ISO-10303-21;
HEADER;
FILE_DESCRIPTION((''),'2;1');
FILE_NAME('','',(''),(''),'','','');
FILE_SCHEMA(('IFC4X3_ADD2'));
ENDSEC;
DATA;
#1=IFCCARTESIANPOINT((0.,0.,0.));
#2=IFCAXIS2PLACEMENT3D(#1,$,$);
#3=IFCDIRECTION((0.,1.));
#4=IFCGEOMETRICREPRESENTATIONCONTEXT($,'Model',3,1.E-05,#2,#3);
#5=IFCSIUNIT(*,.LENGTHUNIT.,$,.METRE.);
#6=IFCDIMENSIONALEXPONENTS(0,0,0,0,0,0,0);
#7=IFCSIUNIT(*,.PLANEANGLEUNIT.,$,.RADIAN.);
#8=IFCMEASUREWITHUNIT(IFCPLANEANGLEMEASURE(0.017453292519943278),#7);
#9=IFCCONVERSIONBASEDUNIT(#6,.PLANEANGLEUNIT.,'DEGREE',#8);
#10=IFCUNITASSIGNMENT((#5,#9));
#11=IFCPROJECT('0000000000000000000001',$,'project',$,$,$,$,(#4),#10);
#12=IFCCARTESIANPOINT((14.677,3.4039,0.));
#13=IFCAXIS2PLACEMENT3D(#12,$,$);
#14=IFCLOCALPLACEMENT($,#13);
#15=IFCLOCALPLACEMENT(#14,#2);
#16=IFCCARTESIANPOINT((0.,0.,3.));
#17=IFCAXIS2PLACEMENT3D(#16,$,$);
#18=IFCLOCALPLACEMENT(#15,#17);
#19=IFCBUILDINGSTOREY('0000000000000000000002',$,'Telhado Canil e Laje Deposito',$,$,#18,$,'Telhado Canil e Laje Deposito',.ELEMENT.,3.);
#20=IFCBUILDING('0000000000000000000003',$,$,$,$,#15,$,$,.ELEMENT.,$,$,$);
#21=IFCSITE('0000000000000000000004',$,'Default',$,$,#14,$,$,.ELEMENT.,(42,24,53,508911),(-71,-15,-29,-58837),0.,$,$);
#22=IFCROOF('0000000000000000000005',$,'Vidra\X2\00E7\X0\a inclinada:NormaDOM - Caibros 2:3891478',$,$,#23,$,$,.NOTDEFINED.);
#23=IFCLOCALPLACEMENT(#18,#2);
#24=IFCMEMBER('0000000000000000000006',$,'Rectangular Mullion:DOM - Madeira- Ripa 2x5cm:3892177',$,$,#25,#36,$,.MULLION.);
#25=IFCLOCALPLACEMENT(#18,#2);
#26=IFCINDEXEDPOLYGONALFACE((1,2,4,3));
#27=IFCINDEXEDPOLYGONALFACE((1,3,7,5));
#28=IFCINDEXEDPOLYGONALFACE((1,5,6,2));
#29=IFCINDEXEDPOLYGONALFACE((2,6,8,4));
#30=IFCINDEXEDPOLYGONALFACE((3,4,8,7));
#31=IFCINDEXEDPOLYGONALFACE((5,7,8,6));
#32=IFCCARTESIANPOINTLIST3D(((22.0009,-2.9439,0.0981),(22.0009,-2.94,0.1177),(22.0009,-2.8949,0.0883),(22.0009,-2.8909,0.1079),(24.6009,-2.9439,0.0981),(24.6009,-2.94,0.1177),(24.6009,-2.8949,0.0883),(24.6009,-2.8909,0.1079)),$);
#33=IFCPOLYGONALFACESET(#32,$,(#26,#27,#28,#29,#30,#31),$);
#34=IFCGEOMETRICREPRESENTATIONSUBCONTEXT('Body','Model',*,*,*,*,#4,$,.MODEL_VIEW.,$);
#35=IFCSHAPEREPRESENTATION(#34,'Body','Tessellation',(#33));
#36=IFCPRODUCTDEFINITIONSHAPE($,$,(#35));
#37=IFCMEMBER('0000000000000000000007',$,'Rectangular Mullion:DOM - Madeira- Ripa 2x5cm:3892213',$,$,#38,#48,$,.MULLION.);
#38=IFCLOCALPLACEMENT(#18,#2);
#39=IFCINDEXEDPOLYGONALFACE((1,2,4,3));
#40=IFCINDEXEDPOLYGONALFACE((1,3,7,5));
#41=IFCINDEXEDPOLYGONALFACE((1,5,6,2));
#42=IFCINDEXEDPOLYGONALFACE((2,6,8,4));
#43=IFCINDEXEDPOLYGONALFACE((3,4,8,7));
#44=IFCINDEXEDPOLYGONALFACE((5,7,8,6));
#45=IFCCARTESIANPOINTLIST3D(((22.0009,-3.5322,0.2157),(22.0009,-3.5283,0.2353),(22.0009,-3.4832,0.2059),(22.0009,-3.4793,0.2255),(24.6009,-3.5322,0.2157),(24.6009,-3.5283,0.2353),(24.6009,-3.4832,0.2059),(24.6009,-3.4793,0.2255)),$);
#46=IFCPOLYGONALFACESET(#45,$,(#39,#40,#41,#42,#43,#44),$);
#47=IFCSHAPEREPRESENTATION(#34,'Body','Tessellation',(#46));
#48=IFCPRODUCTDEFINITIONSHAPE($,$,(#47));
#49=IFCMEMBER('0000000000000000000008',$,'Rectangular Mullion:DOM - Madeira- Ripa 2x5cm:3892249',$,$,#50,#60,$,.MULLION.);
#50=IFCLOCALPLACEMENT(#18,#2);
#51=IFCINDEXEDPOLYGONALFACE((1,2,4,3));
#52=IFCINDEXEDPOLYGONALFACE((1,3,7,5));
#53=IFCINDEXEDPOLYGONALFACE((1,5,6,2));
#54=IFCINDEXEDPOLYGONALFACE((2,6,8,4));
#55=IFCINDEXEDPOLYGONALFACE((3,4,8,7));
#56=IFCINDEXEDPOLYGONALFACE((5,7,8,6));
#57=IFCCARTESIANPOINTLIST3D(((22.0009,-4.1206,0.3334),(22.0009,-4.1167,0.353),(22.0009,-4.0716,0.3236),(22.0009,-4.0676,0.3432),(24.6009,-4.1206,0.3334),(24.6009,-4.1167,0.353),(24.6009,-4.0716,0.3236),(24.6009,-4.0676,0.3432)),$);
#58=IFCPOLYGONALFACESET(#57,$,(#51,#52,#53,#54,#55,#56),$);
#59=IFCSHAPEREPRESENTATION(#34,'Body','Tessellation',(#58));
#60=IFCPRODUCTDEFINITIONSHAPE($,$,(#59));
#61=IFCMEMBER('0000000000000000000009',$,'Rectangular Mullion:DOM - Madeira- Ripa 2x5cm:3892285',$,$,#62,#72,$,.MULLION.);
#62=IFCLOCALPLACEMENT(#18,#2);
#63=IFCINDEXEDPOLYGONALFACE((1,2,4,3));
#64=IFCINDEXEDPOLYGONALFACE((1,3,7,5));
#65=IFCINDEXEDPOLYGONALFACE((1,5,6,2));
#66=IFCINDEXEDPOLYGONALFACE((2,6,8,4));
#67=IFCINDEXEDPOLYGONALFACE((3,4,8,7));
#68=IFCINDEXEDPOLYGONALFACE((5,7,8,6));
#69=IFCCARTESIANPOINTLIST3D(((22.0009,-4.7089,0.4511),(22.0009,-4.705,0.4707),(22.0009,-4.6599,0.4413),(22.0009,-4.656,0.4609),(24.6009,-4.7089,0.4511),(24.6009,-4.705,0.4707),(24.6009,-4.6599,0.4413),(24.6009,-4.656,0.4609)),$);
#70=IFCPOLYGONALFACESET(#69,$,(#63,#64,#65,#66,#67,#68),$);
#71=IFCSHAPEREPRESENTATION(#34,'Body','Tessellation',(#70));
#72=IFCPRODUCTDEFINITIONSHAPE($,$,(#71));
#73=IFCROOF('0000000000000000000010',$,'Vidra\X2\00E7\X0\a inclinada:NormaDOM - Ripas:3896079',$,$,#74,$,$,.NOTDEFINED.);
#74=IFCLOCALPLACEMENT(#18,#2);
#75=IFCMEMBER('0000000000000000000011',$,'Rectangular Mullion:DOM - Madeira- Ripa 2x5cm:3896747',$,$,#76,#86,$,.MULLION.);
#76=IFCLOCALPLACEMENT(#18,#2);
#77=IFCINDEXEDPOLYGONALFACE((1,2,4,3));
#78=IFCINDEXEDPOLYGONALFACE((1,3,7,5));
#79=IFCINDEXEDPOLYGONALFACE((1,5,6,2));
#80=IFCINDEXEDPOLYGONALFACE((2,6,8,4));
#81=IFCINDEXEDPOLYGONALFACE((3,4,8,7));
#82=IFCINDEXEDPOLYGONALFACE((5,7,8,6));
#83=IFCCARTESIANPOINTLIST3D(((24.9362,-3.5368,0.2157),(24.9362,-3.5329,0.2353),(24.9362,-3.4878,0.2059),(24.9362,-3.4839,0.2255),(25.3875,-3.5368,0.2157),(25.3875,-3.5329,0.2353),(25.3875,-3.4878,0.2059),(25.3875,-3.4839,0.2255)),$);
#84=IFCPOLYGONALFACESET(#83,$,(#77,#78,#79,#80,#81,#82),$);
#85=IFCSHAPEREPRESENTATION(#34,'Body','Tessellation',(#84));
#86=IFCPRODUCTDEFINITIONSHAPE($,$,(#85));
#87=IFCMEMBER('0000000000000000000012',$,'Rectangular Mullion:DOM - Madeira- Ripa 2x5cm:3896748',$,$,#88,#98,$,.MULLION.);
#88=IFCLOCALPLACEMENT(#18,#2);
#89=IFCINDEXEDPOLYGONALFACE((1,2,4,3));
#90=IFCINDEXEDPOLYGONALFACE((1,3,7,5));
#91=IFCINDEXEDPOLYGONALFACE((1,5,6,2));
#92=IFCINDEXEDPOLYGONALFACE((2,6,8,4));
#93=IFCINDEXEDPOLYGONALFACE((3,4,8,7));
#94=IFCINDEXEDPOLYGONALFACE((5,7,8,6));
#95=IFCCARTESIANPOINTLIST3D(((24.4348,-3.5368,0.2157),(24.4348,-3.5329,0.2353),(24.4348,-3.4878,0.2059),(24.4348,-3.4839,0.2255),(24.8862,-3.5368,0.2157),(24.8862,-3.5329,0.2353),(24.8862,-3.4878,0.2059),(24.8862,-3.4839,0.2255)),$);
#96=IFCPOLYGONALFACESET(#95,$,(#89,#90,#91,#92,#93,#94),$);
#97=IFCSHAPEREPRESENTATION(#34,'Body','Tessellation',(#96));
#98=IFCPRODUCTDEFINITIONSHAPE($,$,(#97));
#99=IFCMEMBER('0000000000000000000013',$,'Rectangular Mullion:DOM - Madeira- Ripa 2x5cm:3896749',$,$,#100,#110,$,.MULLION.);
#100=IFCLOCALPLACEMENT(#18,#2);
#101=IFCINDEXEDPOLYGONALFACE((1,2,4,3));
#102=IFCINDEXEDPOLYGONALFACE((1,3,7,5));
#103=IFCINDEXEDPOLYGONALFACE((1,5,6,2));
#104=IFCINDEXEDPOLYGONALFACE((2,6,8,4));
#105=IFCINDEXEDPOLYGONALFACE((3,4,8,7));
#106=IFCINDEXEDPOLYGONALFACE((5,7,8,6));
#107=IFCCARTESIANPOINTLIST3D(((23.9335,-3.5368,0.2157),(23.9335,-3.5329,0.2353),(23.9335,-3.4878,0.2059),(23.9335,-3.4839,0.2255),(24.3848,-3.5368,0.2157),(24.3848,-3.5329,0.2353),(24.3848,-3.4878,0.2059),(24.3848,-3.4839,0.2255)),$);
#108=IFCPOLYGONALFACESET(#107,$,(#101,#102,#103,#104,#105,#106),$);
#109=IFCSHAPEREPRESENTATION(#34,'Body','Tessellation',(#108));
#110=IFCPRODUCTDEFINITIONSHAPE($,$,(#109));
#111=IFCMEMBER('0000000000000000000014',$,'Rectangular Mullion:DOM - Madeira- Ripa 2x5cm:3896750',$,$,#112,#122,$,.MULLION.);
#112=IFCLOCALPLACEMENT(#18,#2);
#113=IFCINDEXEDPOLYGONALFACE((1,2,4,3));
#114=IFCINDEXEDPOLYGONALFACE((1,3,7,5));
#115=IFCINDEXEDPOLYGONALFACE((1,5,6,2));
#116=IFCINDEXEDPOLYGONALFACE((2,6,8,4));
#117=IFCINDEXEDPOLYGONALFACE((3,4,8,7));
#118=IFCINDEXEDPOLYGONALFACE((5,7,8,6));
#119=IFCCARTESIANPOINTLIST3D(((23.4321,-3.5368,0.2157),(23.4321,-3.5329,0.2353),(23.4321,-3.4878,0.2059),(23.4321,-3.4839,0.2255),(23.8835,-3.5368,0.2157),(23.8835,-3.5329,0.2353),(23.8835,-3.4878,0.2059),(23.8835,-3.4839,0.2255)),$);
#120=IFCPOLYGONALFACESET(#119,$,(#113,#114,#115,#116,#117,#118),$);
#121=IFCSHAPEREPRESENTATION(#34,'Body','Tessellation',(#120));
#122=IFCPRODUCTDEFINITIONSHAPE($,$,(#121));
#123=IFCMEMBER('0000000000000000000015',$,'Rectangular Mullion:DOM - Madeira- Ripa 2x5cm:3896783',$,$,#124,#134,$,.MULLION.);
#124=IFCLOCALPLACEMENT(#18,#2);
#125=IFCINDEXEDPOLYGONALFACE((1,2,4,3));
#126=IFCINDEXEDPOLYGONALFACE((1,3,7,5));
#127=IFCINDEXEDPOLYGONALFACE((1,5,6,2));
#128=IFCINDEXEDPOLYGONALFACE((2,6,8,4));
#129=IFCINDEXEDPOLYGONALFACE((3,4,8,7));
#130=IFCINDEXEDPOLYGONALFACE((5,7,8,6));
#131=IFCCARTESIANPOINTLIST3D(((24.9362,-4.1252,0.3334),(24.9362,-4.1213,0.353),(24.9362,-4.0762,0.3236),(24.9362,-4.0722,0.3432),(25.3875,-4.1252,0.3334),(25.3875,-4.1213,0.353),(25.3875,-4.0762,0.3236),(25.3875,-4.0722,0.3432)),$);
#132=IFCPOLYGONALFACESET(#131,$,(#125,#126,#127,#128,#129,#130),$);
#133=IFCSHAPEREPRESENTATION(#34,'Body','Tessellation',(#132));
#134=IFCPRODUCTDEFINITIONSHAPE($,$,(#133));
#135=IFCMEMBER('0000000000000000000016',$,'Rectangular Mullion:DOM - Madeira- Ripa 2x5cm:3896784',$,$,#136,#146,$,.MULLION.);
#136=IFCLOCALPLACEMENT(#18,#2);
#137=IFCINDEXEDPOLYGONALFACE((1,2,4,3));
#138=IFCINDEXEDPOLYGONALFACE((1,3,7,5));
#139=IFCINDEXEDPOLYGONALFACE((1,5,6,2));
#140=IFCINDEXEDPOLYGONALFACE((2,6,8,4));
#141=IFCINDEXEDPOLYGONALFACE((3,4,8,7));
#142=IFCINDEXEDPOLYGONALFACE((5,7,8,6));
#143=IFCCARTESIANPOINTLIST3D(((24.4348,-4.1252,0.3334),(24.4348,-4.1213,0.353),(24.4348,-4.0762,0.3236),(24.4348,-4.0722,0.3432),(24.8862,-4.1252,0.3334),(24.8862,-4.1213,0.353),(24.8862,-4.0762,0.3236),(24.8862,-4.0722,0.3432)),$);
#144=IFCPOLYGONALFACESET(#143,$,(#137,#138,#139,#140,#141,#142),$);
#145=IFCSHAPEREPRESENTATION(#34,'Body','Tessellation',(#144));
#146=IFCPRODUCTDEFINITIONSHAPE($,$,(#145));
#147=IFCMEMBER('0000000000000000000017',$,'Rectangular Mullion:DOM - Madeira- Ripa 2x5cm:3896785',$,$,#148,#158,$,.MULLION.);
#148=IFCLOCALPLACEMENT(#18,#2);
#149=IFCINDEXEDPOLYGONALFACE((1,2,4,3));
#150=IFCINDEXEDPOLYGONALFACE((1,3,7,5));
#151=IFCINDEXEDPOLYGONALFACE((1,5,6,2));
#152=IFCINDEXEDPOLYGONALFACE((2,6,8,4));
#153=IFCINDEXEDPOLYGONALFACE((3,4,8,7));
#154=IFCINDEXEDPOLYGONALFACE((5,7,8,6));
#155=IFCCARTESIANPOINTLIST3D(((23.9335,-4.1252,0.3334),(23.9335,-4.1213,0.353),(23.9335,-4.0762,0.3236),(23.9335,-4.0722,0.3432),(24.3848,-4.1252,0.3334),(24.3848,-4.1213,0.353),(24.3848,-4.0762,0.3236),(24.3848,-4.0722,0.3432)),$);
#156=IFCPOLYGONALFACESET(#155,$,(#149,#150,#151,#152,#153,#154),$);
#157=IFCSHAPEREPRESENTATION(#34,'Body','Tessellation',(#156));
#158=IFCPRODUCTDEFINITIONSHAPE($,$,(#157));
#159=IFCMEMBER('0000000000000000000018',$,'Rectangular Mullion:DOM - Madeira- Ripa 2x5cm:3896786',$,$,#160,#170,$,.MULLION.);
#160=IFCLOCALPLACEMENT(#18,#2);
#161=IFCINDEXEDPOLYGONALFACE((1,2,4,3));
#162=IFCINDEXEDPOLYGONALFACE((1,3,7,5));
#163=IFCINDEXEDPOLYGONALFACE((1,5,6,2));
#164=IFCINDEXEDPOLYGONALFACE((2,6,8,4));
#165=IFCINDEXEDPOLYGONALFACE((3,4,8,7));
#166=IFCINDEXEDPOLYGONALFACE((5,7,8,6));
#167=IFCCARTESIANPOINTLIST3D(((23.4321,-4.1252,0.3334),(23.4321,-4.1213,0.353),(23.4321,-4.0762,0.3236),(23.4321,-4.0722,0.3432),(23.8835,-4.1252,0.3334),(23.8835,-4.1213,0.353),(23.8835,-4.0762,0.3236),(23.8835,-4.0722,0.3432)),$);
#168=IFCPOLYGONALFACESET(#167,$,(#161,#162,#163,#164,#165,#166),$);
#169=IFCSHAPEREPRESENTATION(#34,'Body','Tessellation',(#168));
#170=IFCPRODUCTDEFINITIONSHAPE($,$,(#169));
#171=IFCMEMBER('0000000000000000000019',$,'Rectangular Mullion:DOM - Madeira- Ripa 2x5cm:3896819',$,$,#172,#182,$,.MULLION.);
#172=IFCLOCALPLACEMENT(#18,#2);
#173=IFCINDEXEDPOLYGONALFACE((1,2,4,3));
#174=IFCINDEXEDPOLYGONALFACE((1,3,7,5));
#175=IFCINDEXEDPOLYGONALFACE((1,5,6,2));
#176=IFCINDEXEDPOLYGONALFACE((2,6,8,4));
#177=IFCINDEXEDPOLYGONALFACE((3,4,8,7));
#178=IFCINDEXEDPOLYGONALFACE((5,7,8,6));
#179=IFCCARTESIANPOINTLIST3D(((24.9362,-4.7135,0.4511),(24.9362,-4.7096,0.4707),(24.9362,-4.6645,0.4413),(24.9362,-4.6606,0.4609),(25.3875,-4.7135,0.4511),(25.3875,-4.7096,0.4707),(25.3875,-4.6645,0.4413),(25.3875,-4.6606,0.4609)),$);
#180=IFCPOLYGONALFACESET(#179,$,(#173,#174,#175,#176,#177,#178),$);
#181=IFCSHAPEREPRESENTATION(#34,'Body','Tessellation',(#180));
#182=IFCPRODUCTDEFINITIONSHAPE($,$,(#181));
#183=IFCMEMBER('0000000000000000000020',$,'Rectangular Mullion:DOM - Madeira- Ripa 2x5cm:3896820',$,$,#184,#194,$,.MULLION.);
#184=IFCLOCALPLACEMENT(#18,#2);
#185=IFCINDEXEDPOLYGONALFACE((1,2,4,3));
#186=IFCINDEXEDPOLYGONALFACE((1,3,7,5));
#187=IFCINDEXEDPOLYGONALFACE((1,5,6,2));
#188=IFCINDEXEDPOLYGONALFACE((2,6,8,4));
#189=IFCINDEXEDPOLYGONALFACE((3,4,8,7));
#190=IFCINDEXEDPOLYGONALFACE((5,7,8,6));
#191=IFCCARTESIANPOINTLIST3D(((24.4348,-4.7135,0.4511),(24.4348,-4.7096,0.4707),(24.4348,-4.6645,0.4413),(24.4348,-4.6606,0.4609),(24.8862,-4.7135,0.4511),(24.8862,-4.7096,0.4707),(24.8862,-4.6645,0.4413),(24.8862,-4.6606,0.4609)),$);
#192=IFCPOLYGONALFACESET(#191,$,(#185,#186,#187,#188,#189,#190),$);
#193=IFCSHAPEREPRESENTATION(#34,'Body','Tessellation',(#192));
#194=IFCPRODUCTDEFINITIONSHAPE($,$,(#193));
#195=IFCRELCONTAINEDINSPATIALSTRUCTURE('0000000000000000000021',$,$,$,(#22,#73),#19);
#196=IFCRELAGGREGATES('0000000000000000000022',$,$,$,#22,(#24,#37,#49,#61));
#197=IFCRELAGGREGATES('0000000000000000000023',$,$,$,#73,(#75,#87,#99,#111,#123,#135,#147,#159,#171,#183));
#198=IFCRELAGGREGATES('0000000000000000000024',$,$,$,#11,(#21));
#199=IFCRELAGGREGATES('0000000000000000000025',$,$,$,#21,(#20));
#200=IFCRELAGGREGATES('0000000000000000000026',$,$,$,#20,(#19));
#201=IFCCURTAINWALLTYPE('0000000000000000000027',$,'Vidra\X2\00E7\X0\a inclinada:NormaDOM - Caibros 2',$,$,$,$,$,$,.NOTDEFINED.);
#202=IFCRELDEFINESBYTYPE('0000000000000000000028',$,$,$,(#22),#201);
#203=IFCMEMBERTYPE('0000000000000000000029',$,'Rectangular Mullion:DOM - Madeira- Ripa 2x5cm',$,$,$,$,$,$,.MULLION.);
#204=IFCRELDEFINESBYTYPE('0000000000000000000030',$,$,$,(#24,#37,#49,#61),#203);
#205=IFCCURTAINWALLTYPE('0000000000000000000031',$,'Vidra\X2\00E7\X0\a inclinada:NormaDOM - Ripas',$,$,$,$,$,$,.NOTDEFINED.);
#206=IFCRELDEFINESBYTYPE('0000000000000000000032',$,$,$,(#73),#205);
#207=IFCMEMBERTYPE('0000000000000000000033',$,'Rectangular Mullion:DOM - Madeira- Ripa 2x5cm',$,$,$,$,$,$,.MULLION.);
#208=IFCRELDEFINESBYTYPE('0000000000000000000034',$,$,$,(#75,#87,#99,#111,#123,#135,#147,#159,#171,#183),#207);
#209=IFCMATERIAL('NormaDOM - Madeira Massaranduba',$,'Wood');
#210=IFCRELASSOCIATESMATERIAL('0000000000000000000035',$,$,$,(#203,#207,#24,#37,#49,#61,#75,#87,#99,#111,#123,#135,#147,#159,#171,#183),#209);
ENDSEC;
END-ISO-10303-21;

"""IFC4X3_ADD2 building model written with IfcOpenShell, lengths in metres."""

from ifc_helpers import new_model, entity, si_unit, converted_unit, direction, frame, origin, origin_2d_with_axis, place, context, subcontext, project, spatial, rectangle, extrude, source, transform, mapped, material, material_profile, profile_set, profile_usage, type_object, type_shapes, element, aggregate, save


model = new_model("IFC4X3_ADD2")

# Units and contexts
model_context = context("Model", 3, precision=1e-05, world=origin(), true_north=direction((0.0, 1.0)))
body_context = subcontext(model_context, "Body", "Model", "MODEL_VIEW")
ifc_project = project(units=[si_unit("LENGTHUNIT", "METRE"), converted_unit("PLANEANGLEUNIT", "DEGREE", entity("IfcPlaneAngleMeasure", 0.017453292519943278), si_unit("PLANEANGLEUNIT", "RADIAN"), dimensions=[0, 0, 0, 0, 0, 0, 0])], contexts=[model_context])

# Site, building, storey
site_placement = place(None, frame((14.677, 3.4039, 0.0)))
site = spatial("IfcSite", under=ifc_project, at=site_placement, Name="Default", CompositionType="ELEMENT", RefLatitude=(42, 24, 53, 508911), RefLongitude=(-71, -15, -29, -58837), RefElevation=0.0)
building_placement = place(site_placement, origin())
building = spatial("IfcBuilding", under=site, at=building_placement, CompositionType="ELEMENT")
storey_placement = place(building_placement, frame((0.0, 0.0, 3.0)))
storey = spatial("IfcBuildingStorey", under=building, at=storey_placement, Name="Telhado Canil e Laje Deposito", LongName="Telhado Canil e Laje Deposito", CompositionType="ELEMENT", Elevation=3.0)

# Roofs, members
curtain_wall_type_1 = type_object("IfcCurtainWallType", Name="Vidraça inclinada:NormaDOM - Caibros 2", PredefinedType="NOTDEFINED")
roof_1_placement = place(storey_placement, frame((0.0, 0.0, -3.0)))
roof_1 = element("IfcRoof", 1, at=roof_1_placement, inside=storey, type_object=curtain_wall_type_1, Name="Vidraça inclinada:NormaDOM - Caibros 2:3891478", PredefinedType="NOTDEFINED")
ifc_material = material(Name="NormaDOM - Madeira Massaranduba", Category="Wood")
ifc_material_profile_1 = material_profile(ifc_material, rectangle(XDim=0.05, YDim=0.02, at=origin_2d_with_axis()), Name="DOM - Madeira- Ripa 2x5cm")
ifc_profile_set_1 = profile_set([ifc_material_profile_1], Name="DOM - Madeira- Ripa 2x5cm")
ifc_profile_usage_1 = profile_usage(ifc_profile_set_1)
member_type_1 = type_object("IfcMemberType", Name="Rectangular Mullion:DOM - Madeira- Ripa 2x5cm", PredefinedType="MULLION", material=ifc_profile_set_1)
shared_shape_1 = source(origin(), body_context, "Body", "SweptSolid", [
    extrude(rectangle(XDim=0.05, YDim=0.02, at=origin_2d_with_axis()), frame((0.025, 0.01, -2.6), z_axis=(0.0, 0.0, 1.0), x_axis=(-1.0, 0.0, 0.0)), (0.0, 0.0, 1.0), 2.6),
])
type_shapes(member_type_1, [shared_shape_1])
member_1_placement = place(roof_1_placement, frame((24.6009, -2.8909, 3.1079), z_axis=(1.0, 0.0, 0.0), x_axis=(0.0, -0.980581, 0.196116)))
member_1 = element("IfcMember", 2, at=member_1_placement, type_object=member_type_1, material=ifc_profile_usage_1, Name="Rectangular Mullion:DOM - Madeira- Ripa 2x5cm:3892177", PredefinedType="MULLION", context=body_context, shape_type="MappedRepresentation", body=[
    mapped(shared_shape_1, transform((0.0, 0.0, 0.0), scale=1.0)),
])
member_2_placement = place(roof_1_placement, frame((24.6009, -3.4793, 3.2255), z_axis=(1.0, 0.0, 0.0), x_axis=(0.0, -0.980581, 0.196116)))
member_2 = element("IfcMember", 3, at=member_2_placement, type_object=member_type_1, material=ifc_profile_usage_1, Name="Rectangular Mullion:DOM - Madeira- Ripa 2x5cm:3892213", PredefinedType="MULLION", context=body_context, shape_type="MappedRepresentation", body=[
    mapped(shared_shape_1, transform((0.0, 0.0, 0.0), scale=1.0)),
])
member_3_placement = place(roof_1_placement, frame((24.6009, -4.0676, 3.3432), z_axis=(1.0, 0.0, 0.0), x_axis=(0.0, -0.980581, 0.196116)))
member_3 = element("IfcMember", 4, at=member_3_placement, type_object=member_type_1, material=ifc_profile_usage_1, Name="Rectangular Mullion:DOM - Madeira- Ripa 2x5cm:3892249", PredefinedType="MULLION", context=body_context, shape_type="MappedRepresentation", body=[
    mapped(shared_shape_1, transform((0.0, 0.0, 0.0), scale=1.0)),
])
member_4_placement = place(roof_1_placement, frame((24.6009, -4.656, 3.4609), z_axis=(1.0, 0.0, 0.0), x_axis=(0.0, -0.980581, 0.196116)))
member_4 = element("IfcMember", 5, at=member_4_placement, type_object=member_type_1, material=ifc_profile_usage_1, Name="Rectangular Mullion:DOM - Madeira- Ripa 2x5cm:3892285", PredefinedType="MULLION", context=body_context, shape_type="MappedRepresentation", body=[
    mapped(shared_shape_1, transform((0.0, 0.0, 0.0), scale=1.0)),
])
curtain_wall_type_2 = type_object("IfcCurtainWallType", Name="Vidraça inclinada:NormaDOM - Ripas", PredefinedType="NOTDEFINED")
roof_2_placement = place(storey_placement, frame((0.0, 0.0, -3.0)))
roof_2 = element("IfcRoof", 6, at=roof_2_placement, inside=storey, type_object=curtain_wall_type_2, Name="Vidraça inclinada:NormaDOM - Ripas:3896079", PredefinedType="NOTDEFINED")

# Members
aggregate(roof_1, [member_1, member_2, member_3, member_4])
member_type_2 = type_object("IfcMemberType", Name="Rectangular Mullion:DOM - Madeira- Ripa 2x5cm", PredefinedType="MULLION", material=ifc_profile_set_1)
shared_shape_2 = source(origin(), body_context, "Body", "SweptSolid", [
    extrude(rectangle(XDim=0.05, YDim=0.02, at=origin_2d_with_axis()), frame((0.025, 0.01, -0.4514), z_axis=(0.0, 0.0, 1.0), x_axis=(-1.0, 0.0, 0.0)), (0.0, 0.0, 1.0), 0.4514),
])
type_shapes(member_type_2, [shared_shape_2])
member_5_placement = place(roof_2_placement, frame((25.3875, -3.4839, 3.2255), z_axis=(1.0, 0.0, 0.0), x_axis=(0.0, -0.980581, 0.196116)))
member_5 = element("IfcMember", 7, at=member_5_placement, type_object=member_type_2, material=ifc_profile_usage_1, Name="Rectangular Mullion:DOM - Madeira- Ripa 2x5cm:3896747", PredefinedType="MULLION", context=body_context, shape_type="MappedRepresentation", body=[
    mapped(shared_shape_2, transform((0.0, 0.0, 0.0), scale=1.0)),
])
member_6_placement = place(roof_2_placement, frame((24.8862, -3.4839, 3.2255), z_axis=(1.0, 0.0, 0.0), x_axis=(0.0, -0.980581, 0.196116)))
member_6 = element("IfcMember", 8, at=member_6_placement, type_object=member_type_2, material=ifc_profile_usage_1, Name="Rectangular Mullion:DOM - Madeira- Ripa 2x5cm:3896748", PredefinedType="MULLION", context=body_context, shape_type="MappedRepresentation", body=[
    mapped(shared_shape_2, transform((0.0, 0.0, 0.0), scale=1.0)),
])
member_7_placement = place(roof_2_placement, frame((24.3848, -3.4839, 3.2255), z_axis=(1.0, 0.0, 0.0), x_axis=(0.0, -0.980581, 0.196116)))
member_7 = element("IfcMember", 9, at=member_7_placement, type_object=member_type_2, material=ifc_profile_usage_1, Name="Rectangular Mullion:DOM - Madeira- Ripa 2x5cm:3896749", PredefinedType="MULLION", context=body_context, shape_type="MappedRepresentation", body=[
    mapped(shared_shape_2, transform((0.0, 0.0, 0.0), scale=1.0)),
])
member_8_placement = place(roof_2_placement, frame((23.8835, -3.4839, 3.2255), z_axis=(1.0, 0.0, 0.0), x_axis=(0.0, -0.980581, 0.196116)))
member_8 = element("IfcMember", 10, at=member_8_placement, type_object=member_type_2, material=ifc_profile_usage_1, Name="Rectangular Mullion:DOM - Madeira- Ripa 2x5cm:3896750", PredefinedType="MULLION", context=body_context, shape_type="MappedRepresentation", body=[
    mapped(shared_shape_2, transform((0.0, 0.0, 0.0), scale=1.0)),
])
member_9_placement = place(roof_2_placement, frame((25.3875, -4.0722, 3.3432), z_axis=(1.0, 0.0, 0.0), x_axis=(0.0, -0.980581, 0.196116)))
member_9 = element("IfcMember", 11, at=member_9_placement, type_object=member_type_2, material=ifc_profile_usage_1, Name="Rectangular Mullion:DOM - Madeira- Ripa 2x5cm:3896783", PredefinedType="MULLION", context=body_context, shape_type="MappedRepresentation", body=[
    mapped(shared_shape_2, transform((0.0, 0.0, 0.0), scale=1.0)),
])
member_10_placement = place(roof_2_placement, frame((24.8862, -4.0722, 3.3432), z_axis=(1.0, 0.0, 0.0), x_axis=(0.0, -0.980581, 0.196116)))
member_10 = element("IfcMember", 12, at=member_10_placement, type_object=member_type_2, material=ifc_profile_usage_1, Name="Rectangular Mullion:DOM - Madeira- Ripa 2x5cm:3896784", PredefinedType="MULLION", context=body_context, shape_type="MappedRepresentation", body=[
    mapped(shared_shape_2, transform((0.0, 0.0, 0.0), scale=1.0)),
])
member_11_placement = place(roof_2_placement, frame((24.3848, -4.0722, 3.3432), z_axis=(1.0, 0.0, 0.0), x_axis=(0.0, -0.980581, 0.196116)))
member_11 = element("IfcMember", 13, at=member_11_placement, type_object=member_type_2, material=ifc_profile_usage_1, Name="Rectangular Mullion:DOM - Madeira- Ripa 2x5cm:3896785", PredefinedType="MULLION", context=body_context, shape_type="MappedRepresentation", body=[
    mapped(shared_shape_2, transform((0.0, 0.0, 0.0), scale=1.0)),
])
member_12_placement = place(roof_2_placement, frame((23.8835, -4.0722, 3.3432), z_axis=(1.0, 0.0, 0.0), x_axis=(0.0, -0.980581, 0.196116)))
member_12 = element("IfcMember", 14, at=member_12_placement, type_object=member_type_2, material=ifc_profile_usage_1, Name="Rectangular Mullion:DOM - Madeira- Ripa 2x5cm:3896786", PredefinedType="MULLION", context=body_context, shape_type="MappedRepresentation", body=[
    mapped(shared_shape_2, transform((0.0, 0.0, 0.0), scale=1.0)),
])
member_13_placement = place(roof_2_placement, frame((25.3875, -4.6606, 3.4609), z_axis=(1.0, 0.0, 0.0), x_axis=(0.0, -0.980581, 0.196116)))
member_13 = element("IfcMember", 15, at=member_13_placement, type_object=member_type_2, material=ifc_profile_usage_1, Name="Rectangular Mullion:DOM - Madeira- Ripa 2x5cm:3896819", PredefinedType="MULLION", context=body_context, shape_type="MappedRepresentation", body=[
    mapped(shared_shape_2, transform((0.0, 0.0, 0.0), scale=1.0)),
])
member_14_placement = place(roof_2_placement, frame((24.8862, -4.6606, 3.4609), z_axis=(1.0, 0.0, 0.0), x_axis=(0.0, -0.980581, 0.196116)))
member_14 = element("IfcMember", 16, at=member_14_placement, type_object=member_type_2, material=ifc_profile_usage_1, Name="Rectangular Mullion:DOM - Madeira- Ripa 2x5cm:3896820", PredefinedType="MULLION", context=body_context, shape_type="MappedRepresentation", body=[
    mapped(shared_shape_2, transform((0.0, 0.0, 0.0), scale=1.0)),
])
aggregate(roof_2, [member_5, member_6, member_7, member_8, member_9, member_10, member_11, member_12, member_13, member_14])

save(model, "model.ifc")
